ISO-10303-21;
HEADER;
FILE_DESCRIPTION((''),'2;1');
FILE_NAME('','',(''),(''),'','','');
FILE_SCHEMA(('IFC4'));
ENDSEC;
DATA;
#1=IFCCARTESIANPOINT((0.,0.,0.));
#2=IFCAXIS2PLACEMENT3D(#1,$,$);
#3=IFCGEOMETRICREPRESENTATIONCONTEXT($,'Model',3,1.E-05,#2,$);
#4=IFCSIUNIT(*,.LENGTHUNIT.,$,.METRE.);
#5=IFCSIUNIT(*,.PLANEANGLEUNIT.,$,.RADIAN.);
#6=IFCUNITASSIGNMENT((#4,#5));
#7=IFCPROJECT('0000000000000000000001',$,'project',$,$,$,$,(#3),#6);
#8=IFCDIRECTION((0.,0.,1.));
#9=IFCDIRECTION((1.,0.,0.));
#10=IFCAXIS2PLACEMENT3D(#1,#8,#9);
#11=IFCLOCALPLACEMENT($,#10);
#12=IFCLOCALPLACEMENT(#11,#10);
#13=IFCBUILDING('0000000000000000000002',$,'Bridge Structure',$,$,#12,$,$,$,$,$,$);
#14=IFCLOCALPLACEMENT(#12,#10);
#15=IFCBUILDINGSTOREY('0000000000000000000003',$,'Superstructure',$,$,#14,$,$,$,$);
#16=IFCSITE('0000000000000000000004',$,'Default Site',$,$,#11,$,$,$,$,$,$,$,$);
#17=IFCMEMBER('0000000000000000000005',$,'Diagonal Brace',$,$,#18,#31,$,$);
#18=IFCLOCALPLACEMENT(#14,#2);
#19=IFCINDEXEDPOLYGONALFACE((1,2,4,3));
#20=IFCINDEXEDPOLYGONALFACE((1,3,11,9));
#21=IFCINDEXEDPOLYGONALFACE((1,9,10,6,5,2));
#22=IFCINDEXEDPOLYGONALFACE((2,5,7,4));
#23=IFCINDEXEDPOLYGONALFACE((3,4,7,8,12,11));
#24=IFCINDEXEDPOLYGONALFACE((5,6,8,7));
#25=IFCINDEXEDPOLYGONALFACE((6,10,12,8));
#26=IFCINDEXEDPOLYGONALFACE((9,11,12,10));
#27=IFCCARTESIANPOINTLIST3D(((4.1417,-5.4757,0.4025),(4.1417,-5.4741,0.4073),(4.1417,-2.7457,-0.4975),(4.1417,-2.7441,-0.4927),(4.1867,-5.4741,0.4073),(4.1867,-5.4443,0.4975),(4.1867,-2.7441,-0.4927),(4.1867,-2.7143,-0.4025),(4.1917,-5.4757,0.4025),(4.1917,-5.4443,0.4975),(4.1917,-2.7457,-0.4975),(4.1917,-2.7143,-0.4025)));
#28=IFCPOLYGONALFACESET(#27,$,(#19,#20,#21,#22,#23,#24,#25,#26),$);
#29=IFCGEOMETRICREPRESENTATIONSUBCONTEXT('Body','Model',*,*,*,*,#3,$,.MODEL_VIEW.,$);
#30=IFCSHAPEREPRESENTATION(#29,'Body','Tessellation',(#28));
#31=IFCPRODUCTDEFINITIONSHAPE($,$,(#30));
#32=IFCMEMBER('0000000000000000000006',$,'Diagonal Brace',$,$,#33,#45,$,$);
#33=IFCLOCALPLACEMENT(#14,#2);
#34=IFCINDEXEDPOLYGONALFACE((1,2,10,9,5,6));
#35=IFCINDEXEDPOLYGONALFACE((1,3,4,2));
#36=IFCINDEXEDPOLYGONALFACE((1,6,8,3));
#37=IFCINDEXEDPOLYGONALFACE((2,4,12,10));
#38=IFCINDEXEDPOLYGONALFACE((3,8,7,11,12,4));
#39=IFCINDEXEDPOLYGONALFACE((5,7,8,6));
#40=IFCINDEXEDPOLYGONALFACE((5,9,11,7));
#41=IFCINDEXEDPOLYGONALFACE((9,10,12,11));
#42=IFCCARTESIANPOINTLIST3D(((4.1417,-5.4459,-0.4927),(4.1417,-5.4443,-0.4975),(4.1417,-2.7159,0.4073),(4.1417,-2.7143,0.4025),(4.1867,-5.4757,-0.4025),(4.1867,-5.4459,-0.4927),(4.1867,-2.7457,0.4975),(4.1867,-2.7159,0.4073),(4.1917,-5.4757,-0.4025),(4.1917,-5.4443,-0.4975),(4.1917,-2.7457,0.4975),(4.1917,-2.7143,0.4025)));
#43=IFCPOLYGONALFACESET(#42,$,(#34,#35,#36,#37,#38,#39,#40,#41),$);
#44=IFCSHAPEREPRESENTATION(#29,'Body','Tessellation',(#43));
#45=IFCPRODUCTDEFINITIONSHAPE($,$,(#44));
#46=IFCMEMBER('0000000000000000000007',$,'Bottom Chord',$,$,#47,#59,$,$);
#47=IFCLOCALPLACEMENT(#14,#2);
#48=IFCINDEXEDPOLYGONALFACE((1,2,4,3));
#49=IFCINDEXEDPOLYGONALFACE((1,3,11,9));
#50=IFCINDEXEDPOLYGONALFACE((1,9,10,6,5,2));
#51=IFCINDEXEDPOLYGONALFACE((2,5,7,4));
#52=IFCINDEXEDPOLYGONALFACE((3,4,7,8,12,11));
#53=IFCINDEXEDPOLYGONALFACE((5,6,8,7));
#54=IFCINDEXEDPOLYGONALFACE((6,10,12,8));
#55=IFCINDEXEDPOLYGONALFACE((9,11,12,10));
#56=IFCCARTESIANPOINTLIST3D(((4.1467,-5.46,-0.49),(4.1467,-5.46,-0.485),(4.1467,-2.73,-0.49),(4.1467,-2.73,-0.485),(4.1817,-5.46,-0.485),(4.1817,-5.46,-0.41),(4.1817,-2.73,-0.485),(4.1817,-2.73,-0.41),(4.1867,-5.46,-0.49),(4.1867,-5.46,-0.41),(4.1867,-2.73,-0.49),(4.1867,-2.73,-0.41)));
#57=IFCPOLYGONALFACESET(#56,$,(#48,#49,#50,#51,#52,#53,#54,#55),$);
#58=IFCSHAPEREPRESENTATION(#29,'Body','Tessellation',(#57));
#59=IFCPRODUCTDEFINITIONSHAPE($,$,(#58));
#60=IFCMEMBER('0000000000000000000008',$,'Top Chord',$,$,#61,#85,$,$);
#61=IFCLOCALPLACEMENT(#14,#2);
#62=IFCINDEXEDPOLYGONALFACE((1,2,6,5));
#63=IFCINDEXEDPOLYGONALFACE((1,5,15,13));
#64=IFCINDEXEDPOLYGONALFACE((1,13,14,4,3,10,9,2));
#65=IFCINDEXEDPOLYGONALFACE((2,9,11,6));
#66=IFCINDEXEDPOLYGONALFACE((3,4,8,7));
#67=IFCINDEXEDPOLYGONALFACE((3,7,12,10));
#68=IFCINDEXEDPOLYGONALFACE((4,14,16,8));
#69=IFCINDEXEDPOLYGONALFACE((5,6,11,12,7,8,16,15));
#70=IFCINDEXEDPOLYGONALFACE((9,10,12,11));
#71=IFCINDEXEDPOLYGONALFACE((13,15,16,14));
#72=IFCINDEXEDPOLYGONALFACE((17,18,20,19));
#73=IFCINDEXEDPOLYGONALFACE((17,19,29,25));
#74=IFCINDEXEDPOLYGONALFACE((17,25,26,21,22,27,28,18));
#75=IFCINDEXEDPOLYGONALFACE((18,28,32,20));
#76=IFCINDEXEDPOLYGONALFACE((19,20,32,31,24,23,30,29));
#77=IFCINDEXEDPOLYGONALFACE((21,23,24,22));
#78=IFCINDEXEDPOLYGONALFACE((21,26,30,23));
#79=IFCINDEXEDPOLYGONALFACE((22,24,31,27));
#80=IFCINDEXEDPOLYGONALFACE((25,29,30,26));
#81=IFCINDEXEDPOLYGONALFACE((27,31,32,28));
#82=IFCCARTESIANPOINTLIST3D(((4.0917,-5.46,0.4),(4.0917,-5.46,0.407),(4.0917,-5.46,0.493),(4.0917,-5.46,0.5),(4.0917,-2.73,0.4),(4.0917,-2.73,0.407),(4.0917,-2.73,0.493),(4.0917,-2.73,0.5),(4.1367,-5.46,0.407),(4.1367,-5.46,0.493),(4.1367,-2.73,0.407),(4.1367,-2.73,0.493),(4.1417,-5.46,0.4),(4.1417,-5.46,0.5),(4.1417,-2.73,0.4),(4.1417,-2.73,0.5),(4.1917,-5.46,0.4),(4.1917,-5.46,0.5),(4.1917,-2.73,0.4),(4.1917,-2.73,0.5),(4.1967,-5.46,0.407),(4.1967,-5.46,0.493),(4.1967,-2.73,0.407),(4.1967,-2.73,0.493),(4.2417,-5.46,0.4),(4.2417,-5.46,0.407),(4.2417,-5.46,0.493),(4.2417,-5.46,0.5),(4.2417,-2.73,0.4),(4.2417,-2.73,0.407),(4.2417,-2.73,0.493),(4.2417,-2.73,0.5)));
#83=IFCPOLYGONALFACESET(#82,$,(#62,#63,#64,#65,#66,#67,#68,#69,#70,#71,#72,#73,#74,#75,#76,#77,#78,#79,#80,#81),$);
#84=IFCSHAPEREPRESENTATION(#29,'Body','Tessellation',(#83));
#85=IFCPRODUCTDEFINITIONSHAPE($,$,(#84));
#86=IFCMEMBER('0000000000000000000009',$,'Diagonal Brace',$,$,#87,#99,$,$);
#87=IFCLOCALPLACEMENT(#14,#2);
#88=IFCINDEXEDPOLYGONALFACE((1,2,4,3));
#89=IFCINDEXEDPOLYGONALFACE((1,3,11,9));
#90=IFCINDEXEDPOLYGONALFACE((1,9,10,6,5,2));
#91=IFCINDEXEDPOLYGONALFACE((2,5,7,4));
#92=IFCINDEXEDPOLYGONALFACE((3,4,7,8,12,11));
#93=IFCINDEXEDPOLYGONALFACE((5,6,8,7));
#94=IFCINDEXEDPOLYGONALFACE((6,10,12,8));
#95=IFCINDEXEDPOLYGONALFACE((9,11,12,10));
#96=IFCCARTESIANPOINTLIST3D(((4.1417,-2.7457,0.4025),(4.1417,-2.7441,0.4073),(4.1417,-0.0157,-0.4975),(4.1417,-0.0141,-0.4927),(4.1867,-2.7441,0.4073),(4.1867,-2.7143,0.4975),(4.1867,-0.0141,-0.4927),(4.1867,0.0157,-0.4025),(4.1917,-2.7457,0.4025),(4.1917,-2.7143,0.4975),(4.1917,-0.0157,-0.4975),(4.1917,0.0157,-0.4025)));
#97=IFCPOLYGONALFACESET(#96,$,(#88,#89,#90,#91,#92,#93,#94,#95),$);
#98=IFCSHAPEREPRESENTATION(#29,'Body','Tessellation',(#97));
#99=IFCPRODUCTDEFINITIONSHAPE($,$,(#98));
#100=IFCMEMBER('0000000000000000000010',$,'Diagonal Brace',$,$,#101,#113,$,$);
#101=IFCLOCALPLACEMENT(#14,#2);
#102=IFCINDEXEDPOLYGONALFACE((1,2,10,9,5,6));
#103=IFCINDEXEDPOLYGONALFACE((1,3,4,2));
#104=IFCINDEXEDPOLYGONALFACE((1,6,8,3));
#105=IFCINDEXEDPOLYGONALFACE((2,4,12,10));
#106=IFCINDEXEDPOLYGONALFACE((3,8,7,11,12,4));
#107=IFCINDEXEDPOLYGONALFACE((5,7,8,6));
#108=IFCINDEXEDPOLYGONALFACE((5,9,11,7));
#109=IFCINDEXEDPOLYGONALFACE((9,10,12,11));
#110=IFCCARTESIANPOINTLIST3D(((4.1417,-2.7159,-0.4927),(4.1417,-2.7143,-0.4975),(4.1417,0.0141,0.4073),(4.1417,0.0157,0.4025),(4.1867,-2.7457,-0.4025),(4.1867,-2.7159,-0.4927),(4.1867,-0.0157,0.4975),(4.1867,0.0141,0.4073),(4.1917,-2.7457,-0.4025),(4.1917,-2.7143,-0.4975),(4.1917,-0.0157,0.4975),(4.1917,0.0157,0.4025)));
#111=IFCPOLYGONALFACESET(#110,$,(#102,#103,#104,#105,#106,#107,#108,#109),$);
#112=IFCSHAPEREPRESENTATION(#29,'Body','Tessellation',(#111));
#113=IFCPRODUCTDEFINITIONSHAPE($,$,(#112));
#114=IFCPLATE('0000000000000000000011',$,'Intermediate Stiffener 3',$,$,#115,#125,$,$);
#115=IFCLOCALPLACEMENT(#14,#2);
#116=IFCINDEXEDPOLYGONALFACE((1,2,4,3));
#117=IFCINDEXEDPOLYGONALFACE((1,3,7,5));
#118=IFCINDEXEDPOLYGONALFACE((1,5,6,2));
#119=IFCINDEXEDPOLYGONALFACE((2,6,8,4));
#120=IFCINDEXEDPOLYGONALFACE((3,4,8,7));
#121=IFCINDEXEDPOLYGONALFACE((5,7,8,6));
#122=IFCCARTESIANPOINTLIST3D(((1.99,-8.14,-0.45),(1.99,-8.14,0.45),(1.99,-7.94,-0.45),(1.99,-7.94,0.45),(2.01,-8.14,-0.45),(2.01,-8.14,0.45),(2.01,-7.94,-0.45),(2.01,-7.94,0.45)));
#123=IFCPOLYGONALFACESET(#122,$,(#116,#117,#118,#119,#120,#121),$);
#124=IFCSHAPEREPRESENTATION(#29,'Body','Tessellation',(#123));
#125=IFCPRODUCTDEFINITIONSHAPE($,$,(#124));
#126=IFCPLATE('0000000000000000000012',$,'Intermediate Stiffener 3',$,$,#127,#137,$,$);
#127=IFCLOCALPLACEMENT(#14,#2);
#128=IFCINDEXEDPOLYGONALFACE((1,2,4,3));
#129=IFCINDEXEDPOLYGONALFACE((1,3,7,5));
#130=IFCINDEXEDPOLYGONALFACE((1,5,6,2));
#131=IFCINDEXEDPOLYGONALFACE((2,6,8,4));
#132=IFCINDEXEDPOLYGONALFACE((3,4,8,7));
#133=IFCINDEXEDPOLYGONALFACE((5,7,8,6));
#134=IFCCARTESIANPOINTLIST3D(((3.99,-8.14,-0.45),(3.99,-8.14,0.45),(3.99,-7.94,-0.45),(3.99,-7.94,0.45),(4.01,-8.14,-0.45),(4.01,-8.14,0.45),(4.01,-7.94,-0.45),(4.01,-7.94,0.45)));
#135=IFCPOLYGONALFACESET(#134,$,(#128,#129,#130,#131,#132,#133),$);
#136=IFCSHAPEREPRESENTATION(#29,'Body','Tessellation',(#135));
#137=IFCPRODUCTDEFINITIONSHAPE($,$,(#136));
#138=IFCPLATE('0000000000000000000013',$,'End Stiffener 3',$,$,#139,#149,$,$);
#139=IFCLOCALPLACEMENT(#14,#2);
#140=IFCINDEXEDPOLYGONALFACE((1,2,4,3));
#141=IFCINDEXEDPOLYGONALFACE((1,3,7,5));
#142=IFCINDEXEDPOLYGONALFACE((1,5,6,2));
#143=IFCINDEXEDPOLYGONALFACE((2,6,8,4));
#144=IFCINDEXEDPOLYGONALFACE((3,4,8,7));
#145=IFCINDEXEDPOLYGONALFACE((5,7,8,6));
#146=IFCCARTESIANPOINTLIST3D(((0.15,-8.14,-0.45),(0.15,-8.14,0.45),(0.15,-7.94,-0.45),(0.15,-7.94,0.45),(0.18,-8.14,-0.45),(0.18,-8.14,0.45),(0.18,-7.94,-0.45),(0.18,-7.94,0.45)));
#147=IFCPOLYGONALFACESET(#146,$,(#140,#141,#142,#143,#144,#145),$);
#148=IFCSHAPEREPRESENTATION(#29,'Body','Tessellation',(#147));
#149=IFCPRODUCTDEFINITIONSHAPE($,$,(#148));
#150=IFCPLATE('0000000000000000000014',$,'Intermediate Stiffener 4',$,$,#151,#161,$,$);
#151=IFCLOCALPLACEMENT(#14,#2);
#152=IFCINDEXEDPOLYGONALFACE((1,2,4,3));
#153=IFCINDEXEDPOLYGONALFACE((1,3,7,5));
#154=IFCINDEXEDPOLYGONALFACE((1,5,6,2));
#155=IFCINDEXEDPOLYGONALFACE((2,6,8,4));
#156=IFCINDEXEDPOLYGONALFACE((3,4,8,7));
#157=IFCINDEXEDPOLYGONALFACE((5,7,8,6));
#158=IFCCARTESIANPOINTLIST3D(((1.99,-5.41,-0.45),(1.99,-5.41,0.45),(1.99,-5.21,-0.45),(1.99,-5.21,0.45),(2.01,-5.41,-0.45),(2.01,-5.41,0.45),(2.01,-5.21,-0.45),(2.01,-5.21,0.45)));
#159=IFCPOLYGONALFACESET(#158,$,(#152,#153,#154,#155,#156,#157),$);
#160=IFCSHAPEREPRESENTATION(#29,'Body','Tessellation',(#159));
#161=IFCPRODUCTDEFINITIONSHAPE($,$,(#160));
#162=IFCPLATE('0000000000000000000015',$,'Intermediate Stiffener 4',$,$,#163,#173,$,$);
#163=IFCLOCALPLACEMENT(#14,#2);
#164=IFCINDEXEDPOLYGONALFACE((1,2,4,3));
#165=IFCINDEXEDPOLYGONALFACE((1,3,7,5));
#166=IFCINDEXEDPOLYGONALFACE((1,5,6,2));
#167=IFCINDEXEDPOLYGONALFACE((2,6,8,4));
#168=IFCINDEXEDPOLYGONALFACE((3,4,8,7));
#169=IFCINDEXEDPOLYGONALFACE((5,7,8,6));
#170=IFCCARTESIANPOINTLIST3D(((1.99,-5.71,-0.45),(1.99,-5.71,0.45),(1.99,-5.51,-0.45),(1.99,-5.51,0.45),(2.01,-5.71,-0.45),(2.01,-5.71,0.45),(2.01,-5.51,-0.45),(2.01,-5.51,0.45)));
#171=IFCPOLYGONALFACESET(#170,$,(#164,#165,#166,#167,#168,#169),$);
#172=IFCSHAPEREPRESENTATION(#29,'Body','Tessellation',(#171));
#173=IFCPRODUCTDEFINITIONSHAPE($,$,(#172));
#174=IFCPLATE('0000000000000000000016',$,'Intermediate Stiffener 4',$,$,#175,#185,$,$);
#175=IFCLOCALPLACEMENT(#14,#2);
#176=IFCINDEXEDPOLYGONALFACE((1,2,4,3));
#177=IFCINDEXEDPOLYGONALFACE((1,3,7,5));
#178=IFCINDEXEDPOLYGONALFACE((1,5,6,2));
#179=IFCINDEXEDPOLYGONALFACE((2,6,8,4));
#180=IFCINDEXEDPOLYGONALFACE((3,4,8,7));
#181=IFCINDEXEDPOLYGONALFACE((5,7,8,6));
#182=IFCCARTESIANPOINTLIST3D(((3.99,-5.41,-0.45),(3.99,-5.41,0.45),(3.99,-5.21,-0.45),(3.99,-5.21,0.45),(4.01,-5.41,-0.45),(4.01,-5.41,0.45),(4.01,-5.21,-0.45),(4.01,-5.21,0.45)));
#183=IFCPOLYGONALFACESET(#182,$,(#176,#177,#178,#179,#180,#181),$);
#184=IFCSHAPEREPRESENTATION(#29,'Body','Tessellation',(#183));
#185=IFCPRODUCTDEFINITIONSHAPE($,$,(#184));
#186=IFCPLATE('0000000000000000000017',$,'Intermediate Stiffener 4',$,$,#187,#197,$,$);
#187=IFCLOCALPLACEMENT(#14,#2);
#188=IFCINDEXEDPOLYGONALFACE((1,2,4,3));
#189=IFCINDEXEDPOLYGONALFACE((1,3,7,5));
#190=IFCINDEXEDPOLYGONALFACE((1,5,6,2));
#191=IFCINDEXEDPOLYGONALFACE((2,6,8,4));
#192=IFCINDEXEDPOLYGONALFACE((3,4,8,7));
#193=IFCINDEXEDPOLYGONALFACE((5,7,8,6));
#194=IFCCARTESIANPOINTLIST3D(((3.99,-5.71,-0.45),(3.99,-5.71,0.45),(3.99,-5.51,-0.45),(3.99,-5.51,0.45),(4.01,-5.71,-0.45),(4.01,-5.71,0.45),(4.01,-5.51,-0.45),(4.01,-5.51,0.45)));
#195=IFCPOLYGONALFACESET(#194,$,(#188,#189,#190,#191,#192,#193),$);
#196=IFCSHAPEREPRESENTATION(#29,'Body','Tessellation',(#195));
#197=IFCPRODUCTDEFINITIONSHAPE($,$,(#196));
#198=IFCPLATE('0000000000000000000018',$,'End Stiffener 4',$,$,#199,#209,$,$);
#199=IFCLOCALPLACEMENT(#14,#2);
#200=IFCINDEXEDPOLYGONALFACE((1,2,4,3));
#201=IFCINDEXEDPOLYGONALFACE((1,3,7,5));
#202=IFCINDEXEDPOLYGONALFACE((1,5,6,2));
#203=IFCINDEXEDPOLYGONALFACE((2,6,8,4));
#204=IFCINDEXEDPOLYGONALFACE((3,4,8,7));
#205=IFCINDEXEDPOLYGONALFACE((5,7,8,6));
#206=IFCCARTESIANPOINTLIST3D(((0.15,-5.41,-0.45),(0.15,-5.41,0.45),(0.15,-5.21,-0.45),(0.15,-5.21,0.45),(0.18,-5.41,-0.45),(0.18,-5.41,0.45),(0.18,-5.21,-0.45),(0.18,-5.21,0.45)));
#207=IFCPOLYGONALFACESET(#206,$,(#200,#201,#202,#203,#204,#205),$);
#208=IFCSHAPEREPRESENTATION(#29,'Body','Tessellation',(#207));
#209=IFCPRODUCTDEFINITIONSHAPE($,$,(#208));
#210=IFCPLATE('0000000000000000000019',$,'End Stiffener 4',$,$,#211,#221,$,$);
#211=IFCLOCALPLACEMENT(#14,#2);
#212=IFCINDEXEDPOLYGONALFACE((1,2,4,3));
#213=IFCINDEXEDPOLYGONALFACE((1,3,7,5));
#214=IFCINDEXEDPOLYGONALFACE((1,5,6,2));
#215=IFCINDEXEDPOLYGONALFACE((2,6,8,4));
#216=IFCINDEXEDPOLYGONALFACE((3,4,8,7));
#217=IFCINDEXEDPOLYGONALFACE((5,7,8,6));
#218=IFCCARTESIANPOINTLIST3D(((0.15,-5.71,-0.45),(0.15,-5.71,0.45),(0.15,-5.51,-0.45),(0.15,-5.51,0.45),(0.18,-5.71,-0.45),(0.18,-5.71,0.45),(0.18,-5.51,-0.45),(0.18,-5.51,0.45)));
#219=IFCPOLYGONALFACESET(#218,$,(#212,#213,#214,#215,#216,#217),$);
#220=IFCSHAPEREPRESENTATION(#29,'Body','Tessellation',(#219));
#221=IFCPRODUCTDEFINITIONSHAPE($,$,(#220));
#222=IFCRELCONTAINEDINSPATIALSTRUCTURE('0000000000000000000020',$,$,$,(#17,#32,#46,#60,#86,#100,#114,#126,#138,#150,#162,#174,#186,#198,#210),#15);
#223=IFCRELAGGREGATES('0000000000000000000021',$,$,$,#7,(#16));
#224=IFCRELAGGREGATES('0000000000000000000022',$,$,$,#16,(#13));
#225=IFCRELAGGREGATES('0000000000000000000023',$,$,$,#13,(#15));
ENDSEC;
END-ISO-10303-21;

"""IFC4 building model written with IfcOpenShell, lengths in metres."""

from ifc_helpers import new_model, si_unit, frame, origin, origin_with_axes, origin_2d_with_axis, place, context, subcontext, project, spatial, polyline, rectangle, l_section, outline, composite_profile, extrude, element, save


model = new_model("IFC4")

# Units and contexts
model_context = context("Model", 3, precision=1e-05, world=origin())
body_context = subcontext(model_context, "Body", "Model", "MODEL_VIEW")
ifc_project = project(units=[si_unit("LENGTHUNIT", "METRE"), si_unit("PLANEANGLEUNIT", "RADIAN")], contexts=[model_context])

# Site, building, storey
site_placement = place(None, origin_with_axes())
site = spatial("IfcSite", under=ifc_project, at=site_placement, Name="Default Site")
building_placement = place(site_placement, origin_with_axes())
building = spatial("IfcBuilding", under=site, at=building_placement, Name="Bridge Structure")
storey_placement = place(building_placement, origin_with_axes())
storey = spatial("IfcBuildingStorey", under=building, at=storey_placement, Name="Superstructure")

# Members
for number, where, z_axis, x_axis, name in (
    (1, (4.1667, -5.46, 0.45), (0.0, 0.949722, -0.313095), (-1.0, 0.0, 0.0), "Diagonal Brace"),
    (2, (4.1667, -5.46, -0.45), (0.0, 0.949722, 0.313095), (-1.0, 0.0, 0.0), "Diagonal Brace"),
):
    element("IfcMember", number, at=place(storey_placement, frame(where, z_axis=z_axis, x_axis=x_axis)), inside=storey, Name=name, context=body_context, shape_type="SweptSolid", body=[
        extrude(l_section(Depth=0.1, Width=0.05, Thickness=0.005, at=origin_2d_with_axis()), origin_with_axes(), (0.0, 0.0, 1.0), 2.8745),
    ])
member_1_placement = place(storey_placement, frame((4.1667, -5.46, -0.45), z_axis=(0.0, 1.0, 0.0), x_axis=(-1.0, 0.0, 0.0)))
element("IfcMember", 3, at=member_1_placement, inside=storey, Name="Bottom Chord", context=body_context, shape_type="SweptSolid", body=[
    extrude(l_section(Depth=0.08, Width=0.04, Thickness=0.005, at=origin_2d_with_axis()), origin_with_axes(), (0.0, 0.0, 1.0), 2.73),
])
member_2_placement = place(storey_placement, frame((4.1667, -5.46, 0.45), z_axis=(0.0, 1.0, 0.0), x_axis=(-1.0, 0.0, 0.0)))
element("IfcMember", 4, at=member_2_placement, inside=storey, Name="Top Chord", context=body_context, shape_type="SweptSolid", body=[
    extrude(composite_profile([outline(polyline([(-0.025, -0.05), (-0.025, 0.05), (-0.075, 0.05), (-0.075, 0.043), (-0.03, 0.043), (-0.03, -0.043), (-0.075, -0.043), (-0.075, -0.05), (-0.025, -0.05)])), outline(polyline([(0.025, -0.05), (0.075, -0.05), (0.075, -0.043), (0.03, -0.043), (0.03, 0.043), (0.075, 0.043), (0.075, 0.05), (0.025, 0.05), (0.025, -0.05)]))]), origin_with_axes(), (0.0, 0.0, 1.0), 2.73),
])
for number, where, z_axis, x_axis, name in (
    (5, (4.1667, -2.73, 0.45), (0.0, 0.949722, -0.313095), (-1.0, 0.0, 0.0), "Diagonal Brace"),
    (6, (4.1667, -2.73, -0.45), (0.0, 0.949722, 0.313095), (-1.0, 0.0, 0.0), "Diagonal Brace"),
):
    element("IfcMember", number, at=place(storey_placement, frame(where, z_axis=z_axis, x_axis=x_axis)), inside=storey, Name=name, context=body_context, shape_type="SweptSolid", body=[
        extrude(l_section(Depth=0.1, Width=0.05, Thickness=0.005, at=origin_2d_with_axis()), origin_with_axes(), (0.0, 0.0, 1.0), 2.8745),
    ])

# Plates
for number, where, z_axis, x_axis, name in (
    (7, (2.0, -8.04, -0.45), (0.0, 0.0, 1.0), (1.0, 0.0, 0.0), "Intermediate Stiffener 3"),
    (8, (4.0, -8.04, -0.45), (0.0, 0.0, 1.0), (1.0, 0.0, 0.0), "Intermediate Stiffener 3"),
):
    element("IfcPlate", number, at=place(storey_placement, frame(where, z_axis=z_axis, x_axis=x_axis)), inside=storey, Name=name, context=body_context, shape_type="SweptSolid", body=[
        extrude(rectangle(XDim=0.02, YDim=0.2, at=origin_2d_with_axis()), origin_with_axes(), (0.0, 0.0, 1.0), 0.9),
    ])
plate_1_placement = place(storey_placement, frame((0.165, -8.04, -0.45), z_axis=(0.0, 0.0, 1.0), x_axis=(1.0, 0.0, 0.0)))
element("IfcPlate", 9, at=plate_1_placement, inside=storey, Name="End Stiffener 3", context=body_context, shape_type="SweptSolid", body=[
    extrude(rectangle(XDim=0.03, YDim=0.2, at=origin_2d_with_axis()), origin_with_axes(), (0.0, 0.0, 1.0), 0.9),
])
for number, where, z_axis, x_axis, name in (
    (10, (2.0, -5.31, -0.45), (0.0, 0.0, 1.0), (1.0, 0.0, 0.0), "Intermediate Stiffener 4"),
    (11, (2.0, -5.61, -0.45), (0.0, 0.0, 1.0), (1.0, 0.0, 0.0), "Intermediate Stiffener 4"),
    (12, (4.0, -5.31, -0.45), (0.0, 0.0, 1.0), (1.0, 0.0, 0.0), "Intermediate Stiffener 4"),
    (13, (4.0, -5.61, -0.45), (0.0, 0.0, 1.0), (1.0, 0.0, 0.0), "Intermediate Stiffener 4"),
):
    element("IfcPlate", number, at=place(storey_placement, frame(where, z_axis=z_axis, x_axis=x_axis)), inside=storey, Name=name, context=body_context, shape_type="SweptSolid", body=[
        extrude(rectangle(XDim=0.02, YDim=0.2, at=origin_2d_with_axis()), origin_with_axes(), (0.0, 0.0, 1.0), 0.9),
    ])
for number, where, z_axis, x_axis, name in (
    (14, (0.165, -5.31, -0.45), (0.0, 0.0, 1.0), (1.0, 0.0, 0.0), "End Stiffener 4"),
    (15, (0.165, -5.61, -0.45), (0.0, 0.0, 1.0), (1.0, 0.0, 0.0), "End Stiffener 4"),
):
    element("IfcPlate", number, at=place(storey_placement, frame(where, z_axis=z_axis, x_axis=x_axis)), inside=storey, Name=name, context=body_context, shape_type="SweptSolid", body=[
        extrude(rectangle(XDim=0.03, YDim=0.2, at=origin_2d_with_axis()), origin_with_axes(), (0.0, 0.0, 1.0), 0.9),
    ])

save(model, "model.ifc")
